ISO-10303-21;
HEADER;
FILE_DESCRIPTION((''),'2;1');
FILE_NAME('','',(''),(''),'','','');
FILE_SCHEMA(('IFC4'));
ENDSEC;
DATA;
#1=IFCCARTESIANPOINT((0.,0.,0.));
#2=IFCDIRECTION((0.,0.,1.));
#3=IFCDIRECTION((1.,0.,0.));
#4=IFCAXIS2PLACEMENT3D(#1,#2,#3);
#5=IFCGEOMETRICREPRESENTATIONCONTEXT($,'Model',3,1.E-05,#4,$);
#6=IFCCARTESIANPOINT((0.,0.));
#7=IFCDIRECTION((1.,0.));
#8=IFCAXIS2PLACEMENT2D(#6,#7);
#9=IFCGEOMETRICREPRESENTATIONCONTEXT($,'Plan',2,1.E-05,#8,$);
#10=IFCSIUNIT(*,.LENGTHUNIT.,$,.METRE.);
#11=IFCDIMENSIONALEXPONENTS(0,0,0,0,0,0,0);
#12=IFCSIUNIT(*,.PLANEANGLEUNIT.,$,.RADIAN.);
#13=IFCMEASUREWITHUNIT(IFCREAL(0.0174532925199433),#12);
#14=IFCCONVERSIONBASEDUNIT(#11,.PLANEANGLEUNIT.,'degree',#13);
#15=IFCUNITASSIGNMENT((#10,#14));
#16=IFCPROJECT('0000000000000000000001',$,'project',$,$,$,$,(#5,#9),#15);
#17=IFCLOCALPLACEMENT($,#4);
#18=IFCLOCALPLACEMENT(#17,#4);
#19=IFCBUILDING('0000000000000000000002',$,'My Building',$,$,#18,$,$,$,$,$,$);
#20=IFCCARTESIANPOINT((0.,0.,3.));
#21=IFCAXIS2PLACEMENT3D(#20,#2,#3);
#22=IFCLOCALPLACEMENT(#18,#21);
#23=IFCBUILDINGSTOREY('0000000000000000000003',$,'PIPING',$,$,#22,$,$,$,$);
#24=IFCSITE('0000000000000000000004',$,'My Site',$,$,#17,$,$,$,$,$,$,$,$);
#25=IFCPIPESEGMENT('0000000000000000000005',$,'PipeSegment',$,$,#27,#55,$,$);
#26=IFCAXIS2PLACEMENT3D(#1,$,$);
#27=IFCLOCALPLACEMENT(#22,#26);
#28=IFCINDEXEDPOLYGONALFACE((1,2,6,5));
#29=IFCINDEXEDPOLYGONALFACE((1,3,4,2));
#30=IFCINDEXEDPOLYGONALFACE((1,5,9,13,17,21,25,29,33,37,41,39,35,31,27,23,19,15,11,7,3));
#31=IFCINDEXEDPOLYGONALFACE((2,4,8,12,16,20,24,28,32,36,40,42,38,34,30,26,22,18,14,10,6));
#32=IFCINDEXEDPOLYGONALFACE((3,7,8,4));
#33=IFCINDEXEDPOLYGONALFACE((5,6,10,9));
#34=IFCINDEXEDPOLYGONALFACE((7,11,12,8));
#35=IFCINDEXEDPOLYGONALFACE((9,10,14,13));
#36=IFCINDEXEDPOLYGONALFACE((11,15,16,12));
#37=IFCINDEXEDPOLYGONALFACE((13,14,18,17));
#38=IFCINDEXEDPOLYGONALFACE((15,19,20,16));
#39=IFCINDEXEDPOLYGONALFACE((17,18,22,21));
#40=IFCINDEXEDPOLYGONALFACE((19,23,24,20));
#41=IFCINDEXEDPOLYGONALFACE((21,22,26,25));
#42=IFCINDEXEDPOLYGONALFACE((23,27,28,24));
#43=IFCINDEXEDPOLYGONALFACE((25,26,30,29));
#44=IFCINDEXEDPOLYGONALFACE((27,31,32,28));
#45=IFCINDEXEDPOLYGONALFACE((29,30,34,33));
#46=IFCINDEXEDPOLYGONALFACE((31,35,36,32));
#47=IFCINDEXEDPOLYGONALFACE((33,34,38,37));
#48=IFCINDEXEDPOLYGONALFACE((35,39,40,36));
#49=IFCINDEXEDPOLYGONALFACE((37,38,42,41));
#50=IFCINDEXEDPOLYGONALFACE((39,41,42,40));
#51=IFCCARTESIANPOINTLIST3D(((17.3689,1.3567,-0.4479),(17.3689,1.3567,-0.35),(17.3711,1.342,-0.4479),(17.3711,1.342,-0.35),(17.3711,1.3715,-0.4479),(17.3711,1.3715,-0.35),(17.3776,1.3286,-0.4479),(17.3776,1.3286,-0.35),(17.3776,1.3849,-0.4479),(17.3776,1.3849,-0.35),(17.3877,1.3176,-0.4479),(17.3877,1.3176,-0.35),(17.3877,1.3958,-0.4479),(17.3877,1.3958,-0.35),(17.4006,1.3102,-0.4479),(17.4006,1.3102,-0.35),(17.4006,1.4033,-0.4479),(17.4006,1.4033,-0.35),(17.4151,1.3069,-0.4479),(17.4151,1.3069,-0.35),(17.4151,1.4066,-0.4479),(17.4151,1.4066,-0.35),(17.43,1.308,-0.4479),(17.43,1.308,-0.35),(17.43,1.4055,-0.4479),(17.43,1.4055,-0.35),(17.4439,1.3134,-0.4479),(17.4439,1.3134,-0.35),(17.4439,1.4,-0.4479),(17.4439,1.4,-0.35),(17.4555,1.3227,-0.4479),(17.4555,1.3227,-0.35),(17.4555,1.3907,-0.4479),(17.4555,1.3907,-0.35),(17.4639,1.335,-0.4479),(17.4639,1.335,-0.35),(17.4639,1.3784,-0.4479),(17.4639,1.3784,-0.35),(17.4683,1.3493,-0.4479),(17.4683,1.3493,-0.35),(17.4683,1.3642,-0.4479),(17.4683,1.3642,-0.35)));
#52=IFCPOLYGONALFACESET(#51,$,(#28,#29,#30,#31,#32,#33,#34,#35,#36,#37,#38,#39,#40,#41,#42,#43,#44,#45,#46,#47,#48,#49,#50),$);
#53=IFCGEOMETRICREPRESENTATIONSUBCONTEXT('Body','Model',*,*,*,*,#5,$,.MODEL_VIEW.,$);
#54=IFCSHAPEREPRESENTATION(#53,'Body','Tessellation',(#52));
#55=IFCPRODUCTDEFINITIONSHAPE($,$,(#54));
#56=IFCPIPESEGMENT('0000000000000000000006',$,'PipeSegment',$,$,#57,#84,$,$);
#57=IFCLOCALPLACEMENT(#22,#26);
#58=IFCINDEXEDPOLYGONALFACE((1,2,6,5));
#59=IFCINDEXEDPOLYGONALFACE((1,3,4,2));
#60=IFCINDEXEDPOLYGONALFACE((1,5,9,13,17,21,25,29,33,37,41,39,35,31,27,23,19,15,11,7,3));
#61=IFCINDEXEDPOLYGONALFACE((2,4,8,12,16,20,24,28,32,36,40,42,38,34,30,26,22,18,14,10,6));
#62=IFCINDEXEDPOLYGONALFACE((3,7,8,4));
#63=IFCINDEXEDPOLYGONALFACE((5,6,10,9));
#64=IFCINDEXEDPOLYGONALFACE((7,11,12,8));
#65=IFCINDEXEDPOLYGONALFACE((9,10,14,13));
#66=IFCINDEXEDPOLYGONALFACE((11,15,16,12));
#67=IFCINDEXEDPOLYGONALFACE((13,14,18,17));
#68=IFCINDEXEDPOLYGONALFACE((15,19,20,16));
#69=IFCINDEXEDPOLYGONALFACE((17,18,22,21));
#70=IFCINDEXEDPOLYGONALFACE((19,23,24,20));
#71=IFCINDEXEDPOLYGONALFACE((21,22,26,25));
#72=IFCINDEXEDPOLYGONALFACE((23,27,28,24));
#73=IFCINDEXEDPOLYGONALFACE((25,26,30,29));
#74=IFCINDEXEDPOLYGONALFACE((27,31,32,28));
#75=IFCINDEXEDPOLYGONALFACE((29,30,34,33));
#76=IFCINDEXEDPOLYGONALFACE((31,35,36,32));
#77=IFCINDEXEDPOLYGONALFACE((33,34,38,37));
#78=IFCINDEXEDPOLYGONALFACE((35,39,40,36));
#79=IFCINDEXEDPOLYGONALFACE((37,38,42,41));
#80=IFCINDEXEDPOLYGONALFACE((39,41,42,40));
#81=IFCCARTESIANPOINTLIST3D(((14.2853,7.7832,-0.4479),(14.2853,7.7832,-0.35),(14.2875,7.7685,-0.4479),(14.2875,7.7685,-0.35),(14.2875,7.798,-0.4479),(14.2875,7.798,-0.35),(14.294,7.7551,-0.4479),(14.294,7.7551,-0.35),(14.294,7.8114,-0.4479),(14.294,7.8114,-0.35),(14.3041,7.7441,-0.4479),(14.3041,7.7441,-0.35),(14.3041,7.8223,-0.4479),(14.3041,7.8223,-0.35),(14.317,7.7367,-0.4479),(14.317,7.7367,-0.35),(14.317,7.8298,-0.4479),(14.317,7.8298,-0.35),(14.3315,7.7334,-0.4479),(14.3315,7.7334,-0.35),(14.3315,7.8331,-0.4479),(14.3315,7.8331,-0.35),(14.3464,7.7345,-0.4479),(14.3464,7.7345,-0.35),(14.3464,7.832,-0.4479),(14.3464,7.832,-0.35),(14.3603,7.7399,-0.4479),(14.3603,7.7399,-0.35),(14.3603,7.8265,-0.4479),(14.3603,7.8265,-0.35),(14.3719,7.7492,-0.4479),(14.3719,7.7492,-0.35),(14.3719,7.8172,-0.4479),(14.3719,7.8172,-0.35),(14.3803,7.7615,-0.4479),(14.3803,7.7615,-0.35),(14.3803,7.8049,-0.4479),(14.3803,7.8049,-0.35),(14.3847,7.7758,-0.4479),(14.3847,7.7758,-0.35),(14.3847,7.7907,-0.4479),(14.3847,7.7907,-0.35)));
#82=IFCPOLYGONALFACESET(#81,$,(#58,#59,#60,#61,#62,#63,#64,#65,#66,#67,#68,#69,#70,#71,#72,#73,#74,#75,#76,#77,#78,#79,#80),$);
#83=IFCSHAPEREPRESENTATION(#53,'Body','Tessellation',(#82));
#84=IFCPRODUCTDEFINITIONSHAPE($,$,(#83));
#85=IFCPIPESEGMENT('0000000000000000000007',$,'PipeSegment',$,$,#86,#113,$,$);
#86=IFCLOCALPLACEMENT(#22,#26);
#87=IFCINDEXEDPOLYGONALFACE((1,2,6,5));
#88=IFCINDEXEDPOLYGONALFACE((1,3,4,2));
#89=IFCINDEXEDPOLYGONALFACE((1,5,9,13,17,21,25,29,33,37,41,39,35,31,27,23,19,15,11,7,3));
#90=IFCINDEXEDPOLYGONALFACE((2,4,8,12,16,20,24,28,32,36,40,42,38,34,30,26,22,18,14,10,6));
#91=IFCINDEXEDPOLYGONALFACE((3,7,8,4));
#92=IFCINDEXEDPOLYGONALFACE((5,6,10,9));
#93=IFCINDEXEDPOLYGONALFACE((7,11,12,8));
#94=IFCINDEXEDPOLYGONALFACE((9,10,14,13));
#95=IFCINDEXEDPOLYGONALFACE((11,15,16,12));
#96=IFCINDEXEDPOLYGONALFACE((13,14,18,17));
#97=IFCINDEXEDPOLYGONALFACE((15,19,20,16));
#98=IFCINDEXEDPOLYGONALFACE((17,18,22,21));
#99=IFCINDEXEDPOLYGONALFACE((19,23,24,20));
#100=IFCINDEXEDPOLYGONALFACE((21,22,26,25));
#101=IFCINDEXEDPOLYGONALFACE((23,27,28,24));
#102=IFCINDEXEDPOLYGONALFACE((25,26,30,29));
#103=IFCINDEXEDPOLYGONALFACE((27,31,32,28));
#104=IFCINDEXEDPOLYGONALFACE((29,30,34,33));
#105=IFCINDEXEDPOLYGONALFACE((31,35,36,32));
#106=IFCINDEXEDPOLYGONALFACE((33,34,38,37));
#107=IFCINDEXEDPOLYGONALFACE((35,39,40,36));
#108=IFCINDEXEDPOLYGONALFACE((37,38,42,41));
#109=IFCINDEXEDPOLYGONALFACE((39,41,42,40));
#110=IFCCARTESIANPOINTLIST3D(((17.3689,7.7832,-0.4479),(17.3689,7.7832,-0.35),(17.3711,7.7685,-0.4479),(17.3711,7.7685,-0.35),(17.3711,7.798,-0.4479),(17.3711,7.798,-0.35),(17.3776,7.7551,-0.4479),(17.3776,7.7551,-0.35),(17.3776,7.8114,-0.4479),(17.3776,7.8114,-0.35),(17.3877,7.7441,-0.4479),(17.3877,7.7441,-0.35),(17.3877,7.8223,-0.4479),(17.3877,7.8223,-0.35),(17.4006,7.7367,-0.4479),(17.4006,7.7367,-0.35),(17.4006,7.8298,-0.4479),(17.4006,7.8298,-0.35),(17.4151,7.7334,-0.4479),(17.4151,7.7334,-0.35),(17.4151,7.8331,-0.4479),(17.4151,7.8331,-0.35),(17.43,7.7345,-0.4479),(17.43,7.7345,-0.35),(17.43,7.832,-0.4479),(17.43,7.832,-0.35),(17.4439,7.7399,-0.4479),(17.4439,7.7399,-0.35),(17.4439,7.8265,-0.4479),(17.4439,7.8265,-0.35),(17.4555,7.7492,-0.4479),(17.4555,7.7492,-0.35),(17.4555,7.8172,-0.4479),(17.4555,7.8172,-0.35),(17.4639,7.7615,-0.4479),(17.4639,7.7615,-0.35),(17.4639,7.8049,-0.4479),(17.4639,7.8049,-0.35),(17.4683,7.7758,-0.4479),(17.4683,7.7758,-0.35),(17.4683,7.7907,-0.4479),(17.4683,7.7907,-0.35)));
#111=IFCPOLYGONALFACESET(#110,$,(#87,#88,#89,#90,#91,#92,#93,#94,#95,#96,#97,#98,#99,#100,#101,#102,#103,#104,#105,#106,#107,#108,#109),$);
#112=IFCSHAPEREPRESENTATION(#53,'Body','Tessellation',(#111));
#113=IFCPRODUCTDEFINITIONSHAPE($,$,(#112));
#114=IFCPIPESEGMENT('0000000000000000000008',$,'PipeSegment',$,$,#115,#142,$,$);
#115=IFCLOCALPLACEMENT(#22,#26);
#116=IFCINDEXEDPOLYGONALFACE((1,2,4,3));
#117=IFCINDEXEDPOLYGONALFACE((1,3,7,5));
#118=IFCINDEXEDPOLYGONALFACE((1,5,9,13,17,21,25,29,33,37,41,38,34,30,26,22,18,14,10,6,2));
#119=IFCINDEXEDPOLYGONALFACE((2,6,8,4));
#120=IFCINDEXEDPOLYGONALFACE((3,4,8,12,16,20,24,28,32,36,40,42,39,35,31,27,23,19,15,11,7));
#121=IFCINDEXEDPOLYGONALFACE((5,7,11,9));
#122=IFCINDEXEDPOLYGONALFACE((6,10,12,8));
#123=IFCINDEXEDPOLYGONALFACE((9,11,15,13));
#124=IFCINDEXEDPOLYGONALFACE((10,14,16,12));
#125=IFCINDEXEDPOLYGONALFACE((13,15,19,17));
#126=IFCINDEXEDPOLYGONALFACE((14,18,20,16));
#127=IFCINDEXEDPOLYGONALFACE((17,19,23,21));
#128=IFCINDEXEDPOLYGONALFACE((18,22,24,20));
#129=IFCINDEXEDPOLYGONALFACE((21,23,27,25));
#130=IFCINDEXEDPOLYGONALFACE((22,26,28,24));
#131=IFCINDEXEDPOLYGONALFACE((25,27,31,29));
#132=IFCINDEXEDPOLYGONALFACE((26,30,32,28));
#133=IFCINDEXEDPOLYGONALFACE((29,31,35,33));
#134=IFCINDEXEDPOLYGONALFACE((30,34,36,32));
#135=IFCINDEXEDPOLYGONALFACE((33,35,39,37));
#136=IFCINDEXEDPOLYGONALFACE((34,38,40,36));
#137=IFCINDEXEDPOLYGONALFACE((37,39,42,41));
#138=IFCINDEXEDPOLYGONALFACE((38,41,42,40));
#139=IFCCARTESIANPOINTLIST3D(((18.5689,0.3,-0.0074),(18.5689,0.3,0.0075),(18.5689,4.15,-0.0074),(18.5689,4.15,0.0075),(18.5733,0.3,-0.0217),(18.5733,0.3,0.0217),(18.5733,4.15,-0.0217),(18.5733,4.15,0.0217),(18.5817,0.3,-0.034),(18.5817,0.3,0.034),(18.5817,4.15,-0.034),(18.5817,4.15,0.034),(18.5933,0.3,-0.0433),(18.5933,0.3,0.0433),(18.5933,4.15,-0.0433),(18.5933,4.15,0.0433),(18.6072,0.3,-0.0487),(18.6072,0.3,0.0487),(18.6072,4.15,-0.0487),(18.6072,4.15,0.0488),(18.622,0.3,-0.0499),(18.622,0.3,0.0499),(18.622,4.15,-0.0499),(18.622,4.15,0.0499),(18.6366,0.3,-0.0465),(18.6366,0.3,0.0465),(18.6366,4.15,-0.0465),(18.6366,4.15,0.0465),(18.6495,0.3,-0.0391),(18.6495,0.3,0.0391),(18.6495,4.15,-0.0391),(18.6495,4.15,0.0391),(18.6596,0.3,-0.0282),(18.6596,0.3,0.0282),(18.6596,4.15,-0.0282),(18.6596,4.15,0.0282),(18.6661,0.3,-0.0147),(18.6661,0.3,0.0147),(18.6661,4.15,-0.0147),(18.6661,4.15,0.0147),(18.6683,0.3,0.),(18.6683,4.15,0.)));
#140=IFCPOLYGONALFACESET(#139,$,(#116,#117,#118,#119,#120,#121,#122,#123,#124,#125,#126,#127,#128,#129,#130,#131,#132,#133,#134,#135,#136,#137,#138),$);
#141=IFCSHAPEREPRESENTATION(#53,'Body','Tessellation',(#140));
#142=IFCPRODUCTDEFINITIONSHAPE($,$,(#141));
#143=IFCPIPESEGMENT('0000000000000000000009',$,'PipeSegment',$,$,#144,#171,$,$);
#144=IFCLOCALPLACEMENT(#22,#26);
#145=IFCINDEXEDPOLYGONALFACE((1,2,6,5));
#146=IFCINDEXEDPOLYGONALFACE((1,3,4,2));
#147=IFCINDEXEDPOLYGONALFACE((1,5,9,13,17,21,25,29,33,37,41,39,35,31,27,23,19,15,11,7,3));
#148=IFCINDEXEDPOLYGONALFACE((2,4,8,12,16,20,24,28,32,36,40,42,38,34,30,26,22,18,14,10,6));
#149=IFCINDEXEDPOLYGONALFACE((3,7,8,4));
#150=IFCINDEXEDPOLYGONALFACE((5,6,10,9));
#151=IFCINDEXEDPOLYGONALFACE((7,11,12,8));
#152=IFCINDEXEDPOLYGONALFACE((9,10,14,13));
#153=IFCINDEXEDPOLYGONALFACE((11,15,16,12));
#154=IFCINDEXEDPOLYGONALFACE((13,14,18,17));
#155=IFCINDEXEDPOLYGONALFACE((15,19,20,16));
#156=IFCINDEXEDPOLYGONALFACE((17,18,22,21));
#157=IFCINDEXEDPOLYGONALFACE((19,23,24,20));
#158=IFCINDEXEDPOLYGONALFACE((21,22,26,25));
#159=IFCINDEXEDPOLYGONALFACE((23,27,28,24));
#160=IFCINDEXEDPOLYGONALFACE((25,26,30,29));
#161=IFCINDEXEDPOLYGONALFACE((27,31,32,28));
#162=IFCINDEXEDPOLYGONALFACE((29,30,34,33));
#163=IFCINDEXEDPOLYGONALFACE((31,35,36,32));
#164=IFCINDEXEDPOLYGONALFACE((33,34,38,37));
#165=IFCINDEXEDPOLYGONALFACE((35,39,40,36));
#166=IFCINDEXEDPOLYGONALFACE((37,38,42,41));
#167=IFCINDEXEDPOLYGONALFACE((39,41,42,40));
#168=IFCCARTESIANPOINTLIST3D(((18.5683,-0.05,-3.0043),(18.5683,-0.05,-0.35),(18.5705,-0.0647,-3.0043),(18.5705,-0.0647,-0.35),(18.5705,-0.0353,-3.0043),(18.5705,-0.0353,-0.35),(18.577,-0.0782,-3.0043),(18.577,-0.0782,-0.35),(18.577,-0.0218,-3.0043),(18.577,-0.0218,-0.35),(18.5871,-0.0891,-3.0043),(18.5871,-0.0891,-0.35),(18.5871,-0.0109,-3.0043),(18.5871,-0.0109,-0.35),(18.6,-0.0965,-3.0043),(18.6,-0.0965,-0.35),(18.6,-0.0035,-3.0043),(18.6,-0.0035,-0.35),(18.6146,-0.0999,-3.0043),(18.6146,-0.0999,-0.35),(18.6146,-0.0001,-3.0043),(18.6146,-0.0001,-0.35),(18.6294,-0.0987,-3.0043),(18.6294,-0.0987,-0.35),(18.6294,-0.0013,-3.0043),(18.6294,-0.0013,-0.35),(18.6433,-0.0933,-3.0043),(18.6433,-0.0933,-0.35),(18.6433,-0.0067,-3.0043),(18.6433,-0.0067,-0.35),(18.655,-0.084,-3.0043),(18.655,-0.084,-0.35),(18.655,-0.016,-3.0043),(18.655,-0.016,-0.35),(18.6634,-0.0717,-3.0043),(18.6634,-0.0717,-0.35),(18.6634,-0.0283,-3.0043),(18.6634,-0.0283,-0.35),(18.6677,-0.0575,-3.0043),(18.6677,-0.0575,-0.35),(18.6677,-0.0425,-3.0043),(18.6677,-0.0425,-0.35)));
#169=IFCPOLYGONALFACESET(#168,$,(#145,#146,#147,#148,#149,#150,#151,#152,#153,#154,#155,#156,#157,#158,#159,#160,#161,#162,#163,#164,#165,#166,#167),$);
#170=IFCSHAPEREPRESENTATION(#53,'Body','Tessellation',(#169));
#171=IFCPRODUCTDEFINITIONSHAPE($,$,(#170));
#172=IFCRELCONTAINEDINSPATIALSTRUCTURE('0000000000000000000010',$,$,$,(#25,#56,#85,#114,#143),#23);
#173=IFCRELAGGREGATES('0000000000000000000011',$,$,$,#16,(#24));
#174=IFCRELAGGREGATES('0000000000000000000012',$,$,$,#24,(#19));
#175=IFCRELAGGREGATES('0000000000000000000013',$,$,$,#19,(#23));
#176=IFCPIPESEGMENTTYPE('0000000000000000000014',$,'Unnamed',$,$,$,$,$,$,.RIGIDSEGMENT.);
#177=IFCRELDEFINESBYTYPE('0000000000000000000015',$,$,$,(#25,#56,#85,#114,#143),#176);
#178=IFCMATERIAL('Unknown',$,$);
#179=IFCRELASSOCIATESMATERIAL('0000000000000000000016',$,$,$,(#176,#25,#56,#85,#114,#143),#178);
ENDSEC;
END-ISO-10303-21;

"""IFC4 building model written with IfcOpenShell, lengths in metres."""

from ifc_helpers import new_model, entity, si_unit, converted_unit, frame, origin_with_axes, origin_2d_with_axis, place, context, subcontext, project, spatial, circle, extrude, material, material_profile, profile_set, profile_usage, type_object, element, save


model = new_model("IFC4")

# Units and contexts
model_context = context("Model", 3, precision=1e-05, world=origin_with_axes())
plan_context = context("Plan", 2, precision=1e-05, world=origin_2d_with_axis())
body_context = subcontext(model_context, "Body", "Model", "MODEL_VIEW")
ifc_project = project(units=[si_unit("LENGTHUNIT", "METRE"), converted_unit("PLANEANGLEUNIT", "degree", entity("IfcReal", 0.0174532925199433), si_unit("PLANEANGLEUNIT", "RADIAN"), dimensions=[0, 0, 0, 0, 0, 0, 0])], contexts=[model_context, plan_context])

# Site, building, storey
site_placement = place(None, origin_with_axes())
site = spatial("IfcSite", under=ifc_project, at=site_placement, Name="My Site")
building_placement = place(site_placement, origin_with_axes())
building = spatial("IfcBuilding", under=site, at=building_placement, Name="My Building")
storey_placement = place(building_placement, frame((0.0, 0.0, 3.0), z_axis=(0.0, 0.0, 1.0), x_axis=(1.0, 0.0, 0.0)))
storey = spatial("IfcBuildingStorey", under=building, at=storey_placement, Name="PIPING")

# Pipe segments
ifc_material = material(Name="Unknown")
ifc_material_profile_1 = material_profile(ifc_material, circle(Radius=0.05))
ifc_profile_set_1 = profile_set([ifc_material_profile_1])
pipe_segment_type = type_object("IfcPipeSegmentType", Name="Unnamed", PredefinedType="RIGIDSEGMENT", material=ifc_profile_set_1)
ifc_profile_usage_1 = profile_usage(ifc_profile_set_1, cardinal=5)
pipe_segment_1_placement = place(storey_placement, frame((17.4189, 1.3567, -0.35), z_axis=(0.0, 0.0, -1.0), x_axis=(-1.0, 0.0, 0.0)))
element("IfcPipeSegment", 1, at=pipe_segment_1_placement, inside=storey, type_object=pipe_segment_type, material=ifc_profile_usage_1, Name="PipeSegment", context=body_context, shape_type="SweptSolid", body=[
    extrude(circle(Radius=0.05), origin_with_axes(), (0.0, 0.0, 1.0), 0.0979),
])
ifc_profile_usage_2 = profile_usage(ifc_profile_set_1, cardinal=5)
pipe_segment_2_placement = place(storey_placement, frame((14.3353, 7.7832, -0.35), z_axis=(0.0, 0.0, -1.0), x_axis=(-1.0, 0.0, 0.0)))
element("IfcPipeSegment", 2, at=pipe_segment_2_placement, inside=storey, type_object=pipe_segment_type, material=ifc_profile_usage_2, Name="PipeSegment", context=body_context, shape_type="SweptSolid", body=[
    extrude(circle(Radius=0.05), origin_with_axes(), (0.0, 0.0, 1.0), 0.0979),
])
ifc_profile_usage_3 = profile_usage(ifc_profile_set_1, cardinal=5)
pipe_segment_3_placement = place(storey_placement, frame((17.4189, 7.7832, -0.35), z_axis=(0.0, 0.0, -1.0), x_axis=(-1.0, 0.0, 0.0)))
element("IfcPipeSegment", 3, at=pipe_segment_3_placement, inside=storey, type_object=pipe_segment_type, material=ifc_profile_usage_3, Name="PipeSegment", context=body_context, shape_type="SweptSolid", body=[
    extrude(circle(Radius=0.05), origin_with_axes(), (0.0, 0.0, 1.0), 0.0979),
])
ifc_profile_usage_4 = profile_usage(ifc_profile_set_1, cardinal=5)
pipe_segment_4_placement = place(storey_placement, frame((18.6183, 4.15, 0.0), z_axis=(0.0, -1.0, 0.0), x_axis=(1.0, 0.0, 0.0)))
element("IfcPipeSegment", 4, at=pipe_segment_4_placement, inside=storey, type_object=pipe_segment_type, material=ifc_profile_usage_4, Name="PipeSegment", context=body_context, shape_type="SweptSolid", body=[
    extrude(circle(Radius=0.05), origin_with_axes(), (0.0, 0.0, 1.0), 3.85),
])
ifc_profile_usage_5 = profile_usage(ifc_profile_set_1, cardinal=5)
pipe_segment_5_placement = place(storey_placement, frame((18.6183, -0.05, -0.35), z_axis=(0.0, 0.0, -1.0), x_axis=(-1.0, 0.0, 0.0)))
element("IfcPipeSegment", 5, at=pipe_segment_5_placement, inside=storey, type_object=pipe_segment_type, material=ifc_profile_usage_5, Name="PipeSegment", context=body_context, shape_type="SweptSolid", body=[
    extrude(circle(Radius=0.05), origin_with_axes(), (0.0, 0.0, 1.0), 2.6543),
])

save(model, "model.ifc")
